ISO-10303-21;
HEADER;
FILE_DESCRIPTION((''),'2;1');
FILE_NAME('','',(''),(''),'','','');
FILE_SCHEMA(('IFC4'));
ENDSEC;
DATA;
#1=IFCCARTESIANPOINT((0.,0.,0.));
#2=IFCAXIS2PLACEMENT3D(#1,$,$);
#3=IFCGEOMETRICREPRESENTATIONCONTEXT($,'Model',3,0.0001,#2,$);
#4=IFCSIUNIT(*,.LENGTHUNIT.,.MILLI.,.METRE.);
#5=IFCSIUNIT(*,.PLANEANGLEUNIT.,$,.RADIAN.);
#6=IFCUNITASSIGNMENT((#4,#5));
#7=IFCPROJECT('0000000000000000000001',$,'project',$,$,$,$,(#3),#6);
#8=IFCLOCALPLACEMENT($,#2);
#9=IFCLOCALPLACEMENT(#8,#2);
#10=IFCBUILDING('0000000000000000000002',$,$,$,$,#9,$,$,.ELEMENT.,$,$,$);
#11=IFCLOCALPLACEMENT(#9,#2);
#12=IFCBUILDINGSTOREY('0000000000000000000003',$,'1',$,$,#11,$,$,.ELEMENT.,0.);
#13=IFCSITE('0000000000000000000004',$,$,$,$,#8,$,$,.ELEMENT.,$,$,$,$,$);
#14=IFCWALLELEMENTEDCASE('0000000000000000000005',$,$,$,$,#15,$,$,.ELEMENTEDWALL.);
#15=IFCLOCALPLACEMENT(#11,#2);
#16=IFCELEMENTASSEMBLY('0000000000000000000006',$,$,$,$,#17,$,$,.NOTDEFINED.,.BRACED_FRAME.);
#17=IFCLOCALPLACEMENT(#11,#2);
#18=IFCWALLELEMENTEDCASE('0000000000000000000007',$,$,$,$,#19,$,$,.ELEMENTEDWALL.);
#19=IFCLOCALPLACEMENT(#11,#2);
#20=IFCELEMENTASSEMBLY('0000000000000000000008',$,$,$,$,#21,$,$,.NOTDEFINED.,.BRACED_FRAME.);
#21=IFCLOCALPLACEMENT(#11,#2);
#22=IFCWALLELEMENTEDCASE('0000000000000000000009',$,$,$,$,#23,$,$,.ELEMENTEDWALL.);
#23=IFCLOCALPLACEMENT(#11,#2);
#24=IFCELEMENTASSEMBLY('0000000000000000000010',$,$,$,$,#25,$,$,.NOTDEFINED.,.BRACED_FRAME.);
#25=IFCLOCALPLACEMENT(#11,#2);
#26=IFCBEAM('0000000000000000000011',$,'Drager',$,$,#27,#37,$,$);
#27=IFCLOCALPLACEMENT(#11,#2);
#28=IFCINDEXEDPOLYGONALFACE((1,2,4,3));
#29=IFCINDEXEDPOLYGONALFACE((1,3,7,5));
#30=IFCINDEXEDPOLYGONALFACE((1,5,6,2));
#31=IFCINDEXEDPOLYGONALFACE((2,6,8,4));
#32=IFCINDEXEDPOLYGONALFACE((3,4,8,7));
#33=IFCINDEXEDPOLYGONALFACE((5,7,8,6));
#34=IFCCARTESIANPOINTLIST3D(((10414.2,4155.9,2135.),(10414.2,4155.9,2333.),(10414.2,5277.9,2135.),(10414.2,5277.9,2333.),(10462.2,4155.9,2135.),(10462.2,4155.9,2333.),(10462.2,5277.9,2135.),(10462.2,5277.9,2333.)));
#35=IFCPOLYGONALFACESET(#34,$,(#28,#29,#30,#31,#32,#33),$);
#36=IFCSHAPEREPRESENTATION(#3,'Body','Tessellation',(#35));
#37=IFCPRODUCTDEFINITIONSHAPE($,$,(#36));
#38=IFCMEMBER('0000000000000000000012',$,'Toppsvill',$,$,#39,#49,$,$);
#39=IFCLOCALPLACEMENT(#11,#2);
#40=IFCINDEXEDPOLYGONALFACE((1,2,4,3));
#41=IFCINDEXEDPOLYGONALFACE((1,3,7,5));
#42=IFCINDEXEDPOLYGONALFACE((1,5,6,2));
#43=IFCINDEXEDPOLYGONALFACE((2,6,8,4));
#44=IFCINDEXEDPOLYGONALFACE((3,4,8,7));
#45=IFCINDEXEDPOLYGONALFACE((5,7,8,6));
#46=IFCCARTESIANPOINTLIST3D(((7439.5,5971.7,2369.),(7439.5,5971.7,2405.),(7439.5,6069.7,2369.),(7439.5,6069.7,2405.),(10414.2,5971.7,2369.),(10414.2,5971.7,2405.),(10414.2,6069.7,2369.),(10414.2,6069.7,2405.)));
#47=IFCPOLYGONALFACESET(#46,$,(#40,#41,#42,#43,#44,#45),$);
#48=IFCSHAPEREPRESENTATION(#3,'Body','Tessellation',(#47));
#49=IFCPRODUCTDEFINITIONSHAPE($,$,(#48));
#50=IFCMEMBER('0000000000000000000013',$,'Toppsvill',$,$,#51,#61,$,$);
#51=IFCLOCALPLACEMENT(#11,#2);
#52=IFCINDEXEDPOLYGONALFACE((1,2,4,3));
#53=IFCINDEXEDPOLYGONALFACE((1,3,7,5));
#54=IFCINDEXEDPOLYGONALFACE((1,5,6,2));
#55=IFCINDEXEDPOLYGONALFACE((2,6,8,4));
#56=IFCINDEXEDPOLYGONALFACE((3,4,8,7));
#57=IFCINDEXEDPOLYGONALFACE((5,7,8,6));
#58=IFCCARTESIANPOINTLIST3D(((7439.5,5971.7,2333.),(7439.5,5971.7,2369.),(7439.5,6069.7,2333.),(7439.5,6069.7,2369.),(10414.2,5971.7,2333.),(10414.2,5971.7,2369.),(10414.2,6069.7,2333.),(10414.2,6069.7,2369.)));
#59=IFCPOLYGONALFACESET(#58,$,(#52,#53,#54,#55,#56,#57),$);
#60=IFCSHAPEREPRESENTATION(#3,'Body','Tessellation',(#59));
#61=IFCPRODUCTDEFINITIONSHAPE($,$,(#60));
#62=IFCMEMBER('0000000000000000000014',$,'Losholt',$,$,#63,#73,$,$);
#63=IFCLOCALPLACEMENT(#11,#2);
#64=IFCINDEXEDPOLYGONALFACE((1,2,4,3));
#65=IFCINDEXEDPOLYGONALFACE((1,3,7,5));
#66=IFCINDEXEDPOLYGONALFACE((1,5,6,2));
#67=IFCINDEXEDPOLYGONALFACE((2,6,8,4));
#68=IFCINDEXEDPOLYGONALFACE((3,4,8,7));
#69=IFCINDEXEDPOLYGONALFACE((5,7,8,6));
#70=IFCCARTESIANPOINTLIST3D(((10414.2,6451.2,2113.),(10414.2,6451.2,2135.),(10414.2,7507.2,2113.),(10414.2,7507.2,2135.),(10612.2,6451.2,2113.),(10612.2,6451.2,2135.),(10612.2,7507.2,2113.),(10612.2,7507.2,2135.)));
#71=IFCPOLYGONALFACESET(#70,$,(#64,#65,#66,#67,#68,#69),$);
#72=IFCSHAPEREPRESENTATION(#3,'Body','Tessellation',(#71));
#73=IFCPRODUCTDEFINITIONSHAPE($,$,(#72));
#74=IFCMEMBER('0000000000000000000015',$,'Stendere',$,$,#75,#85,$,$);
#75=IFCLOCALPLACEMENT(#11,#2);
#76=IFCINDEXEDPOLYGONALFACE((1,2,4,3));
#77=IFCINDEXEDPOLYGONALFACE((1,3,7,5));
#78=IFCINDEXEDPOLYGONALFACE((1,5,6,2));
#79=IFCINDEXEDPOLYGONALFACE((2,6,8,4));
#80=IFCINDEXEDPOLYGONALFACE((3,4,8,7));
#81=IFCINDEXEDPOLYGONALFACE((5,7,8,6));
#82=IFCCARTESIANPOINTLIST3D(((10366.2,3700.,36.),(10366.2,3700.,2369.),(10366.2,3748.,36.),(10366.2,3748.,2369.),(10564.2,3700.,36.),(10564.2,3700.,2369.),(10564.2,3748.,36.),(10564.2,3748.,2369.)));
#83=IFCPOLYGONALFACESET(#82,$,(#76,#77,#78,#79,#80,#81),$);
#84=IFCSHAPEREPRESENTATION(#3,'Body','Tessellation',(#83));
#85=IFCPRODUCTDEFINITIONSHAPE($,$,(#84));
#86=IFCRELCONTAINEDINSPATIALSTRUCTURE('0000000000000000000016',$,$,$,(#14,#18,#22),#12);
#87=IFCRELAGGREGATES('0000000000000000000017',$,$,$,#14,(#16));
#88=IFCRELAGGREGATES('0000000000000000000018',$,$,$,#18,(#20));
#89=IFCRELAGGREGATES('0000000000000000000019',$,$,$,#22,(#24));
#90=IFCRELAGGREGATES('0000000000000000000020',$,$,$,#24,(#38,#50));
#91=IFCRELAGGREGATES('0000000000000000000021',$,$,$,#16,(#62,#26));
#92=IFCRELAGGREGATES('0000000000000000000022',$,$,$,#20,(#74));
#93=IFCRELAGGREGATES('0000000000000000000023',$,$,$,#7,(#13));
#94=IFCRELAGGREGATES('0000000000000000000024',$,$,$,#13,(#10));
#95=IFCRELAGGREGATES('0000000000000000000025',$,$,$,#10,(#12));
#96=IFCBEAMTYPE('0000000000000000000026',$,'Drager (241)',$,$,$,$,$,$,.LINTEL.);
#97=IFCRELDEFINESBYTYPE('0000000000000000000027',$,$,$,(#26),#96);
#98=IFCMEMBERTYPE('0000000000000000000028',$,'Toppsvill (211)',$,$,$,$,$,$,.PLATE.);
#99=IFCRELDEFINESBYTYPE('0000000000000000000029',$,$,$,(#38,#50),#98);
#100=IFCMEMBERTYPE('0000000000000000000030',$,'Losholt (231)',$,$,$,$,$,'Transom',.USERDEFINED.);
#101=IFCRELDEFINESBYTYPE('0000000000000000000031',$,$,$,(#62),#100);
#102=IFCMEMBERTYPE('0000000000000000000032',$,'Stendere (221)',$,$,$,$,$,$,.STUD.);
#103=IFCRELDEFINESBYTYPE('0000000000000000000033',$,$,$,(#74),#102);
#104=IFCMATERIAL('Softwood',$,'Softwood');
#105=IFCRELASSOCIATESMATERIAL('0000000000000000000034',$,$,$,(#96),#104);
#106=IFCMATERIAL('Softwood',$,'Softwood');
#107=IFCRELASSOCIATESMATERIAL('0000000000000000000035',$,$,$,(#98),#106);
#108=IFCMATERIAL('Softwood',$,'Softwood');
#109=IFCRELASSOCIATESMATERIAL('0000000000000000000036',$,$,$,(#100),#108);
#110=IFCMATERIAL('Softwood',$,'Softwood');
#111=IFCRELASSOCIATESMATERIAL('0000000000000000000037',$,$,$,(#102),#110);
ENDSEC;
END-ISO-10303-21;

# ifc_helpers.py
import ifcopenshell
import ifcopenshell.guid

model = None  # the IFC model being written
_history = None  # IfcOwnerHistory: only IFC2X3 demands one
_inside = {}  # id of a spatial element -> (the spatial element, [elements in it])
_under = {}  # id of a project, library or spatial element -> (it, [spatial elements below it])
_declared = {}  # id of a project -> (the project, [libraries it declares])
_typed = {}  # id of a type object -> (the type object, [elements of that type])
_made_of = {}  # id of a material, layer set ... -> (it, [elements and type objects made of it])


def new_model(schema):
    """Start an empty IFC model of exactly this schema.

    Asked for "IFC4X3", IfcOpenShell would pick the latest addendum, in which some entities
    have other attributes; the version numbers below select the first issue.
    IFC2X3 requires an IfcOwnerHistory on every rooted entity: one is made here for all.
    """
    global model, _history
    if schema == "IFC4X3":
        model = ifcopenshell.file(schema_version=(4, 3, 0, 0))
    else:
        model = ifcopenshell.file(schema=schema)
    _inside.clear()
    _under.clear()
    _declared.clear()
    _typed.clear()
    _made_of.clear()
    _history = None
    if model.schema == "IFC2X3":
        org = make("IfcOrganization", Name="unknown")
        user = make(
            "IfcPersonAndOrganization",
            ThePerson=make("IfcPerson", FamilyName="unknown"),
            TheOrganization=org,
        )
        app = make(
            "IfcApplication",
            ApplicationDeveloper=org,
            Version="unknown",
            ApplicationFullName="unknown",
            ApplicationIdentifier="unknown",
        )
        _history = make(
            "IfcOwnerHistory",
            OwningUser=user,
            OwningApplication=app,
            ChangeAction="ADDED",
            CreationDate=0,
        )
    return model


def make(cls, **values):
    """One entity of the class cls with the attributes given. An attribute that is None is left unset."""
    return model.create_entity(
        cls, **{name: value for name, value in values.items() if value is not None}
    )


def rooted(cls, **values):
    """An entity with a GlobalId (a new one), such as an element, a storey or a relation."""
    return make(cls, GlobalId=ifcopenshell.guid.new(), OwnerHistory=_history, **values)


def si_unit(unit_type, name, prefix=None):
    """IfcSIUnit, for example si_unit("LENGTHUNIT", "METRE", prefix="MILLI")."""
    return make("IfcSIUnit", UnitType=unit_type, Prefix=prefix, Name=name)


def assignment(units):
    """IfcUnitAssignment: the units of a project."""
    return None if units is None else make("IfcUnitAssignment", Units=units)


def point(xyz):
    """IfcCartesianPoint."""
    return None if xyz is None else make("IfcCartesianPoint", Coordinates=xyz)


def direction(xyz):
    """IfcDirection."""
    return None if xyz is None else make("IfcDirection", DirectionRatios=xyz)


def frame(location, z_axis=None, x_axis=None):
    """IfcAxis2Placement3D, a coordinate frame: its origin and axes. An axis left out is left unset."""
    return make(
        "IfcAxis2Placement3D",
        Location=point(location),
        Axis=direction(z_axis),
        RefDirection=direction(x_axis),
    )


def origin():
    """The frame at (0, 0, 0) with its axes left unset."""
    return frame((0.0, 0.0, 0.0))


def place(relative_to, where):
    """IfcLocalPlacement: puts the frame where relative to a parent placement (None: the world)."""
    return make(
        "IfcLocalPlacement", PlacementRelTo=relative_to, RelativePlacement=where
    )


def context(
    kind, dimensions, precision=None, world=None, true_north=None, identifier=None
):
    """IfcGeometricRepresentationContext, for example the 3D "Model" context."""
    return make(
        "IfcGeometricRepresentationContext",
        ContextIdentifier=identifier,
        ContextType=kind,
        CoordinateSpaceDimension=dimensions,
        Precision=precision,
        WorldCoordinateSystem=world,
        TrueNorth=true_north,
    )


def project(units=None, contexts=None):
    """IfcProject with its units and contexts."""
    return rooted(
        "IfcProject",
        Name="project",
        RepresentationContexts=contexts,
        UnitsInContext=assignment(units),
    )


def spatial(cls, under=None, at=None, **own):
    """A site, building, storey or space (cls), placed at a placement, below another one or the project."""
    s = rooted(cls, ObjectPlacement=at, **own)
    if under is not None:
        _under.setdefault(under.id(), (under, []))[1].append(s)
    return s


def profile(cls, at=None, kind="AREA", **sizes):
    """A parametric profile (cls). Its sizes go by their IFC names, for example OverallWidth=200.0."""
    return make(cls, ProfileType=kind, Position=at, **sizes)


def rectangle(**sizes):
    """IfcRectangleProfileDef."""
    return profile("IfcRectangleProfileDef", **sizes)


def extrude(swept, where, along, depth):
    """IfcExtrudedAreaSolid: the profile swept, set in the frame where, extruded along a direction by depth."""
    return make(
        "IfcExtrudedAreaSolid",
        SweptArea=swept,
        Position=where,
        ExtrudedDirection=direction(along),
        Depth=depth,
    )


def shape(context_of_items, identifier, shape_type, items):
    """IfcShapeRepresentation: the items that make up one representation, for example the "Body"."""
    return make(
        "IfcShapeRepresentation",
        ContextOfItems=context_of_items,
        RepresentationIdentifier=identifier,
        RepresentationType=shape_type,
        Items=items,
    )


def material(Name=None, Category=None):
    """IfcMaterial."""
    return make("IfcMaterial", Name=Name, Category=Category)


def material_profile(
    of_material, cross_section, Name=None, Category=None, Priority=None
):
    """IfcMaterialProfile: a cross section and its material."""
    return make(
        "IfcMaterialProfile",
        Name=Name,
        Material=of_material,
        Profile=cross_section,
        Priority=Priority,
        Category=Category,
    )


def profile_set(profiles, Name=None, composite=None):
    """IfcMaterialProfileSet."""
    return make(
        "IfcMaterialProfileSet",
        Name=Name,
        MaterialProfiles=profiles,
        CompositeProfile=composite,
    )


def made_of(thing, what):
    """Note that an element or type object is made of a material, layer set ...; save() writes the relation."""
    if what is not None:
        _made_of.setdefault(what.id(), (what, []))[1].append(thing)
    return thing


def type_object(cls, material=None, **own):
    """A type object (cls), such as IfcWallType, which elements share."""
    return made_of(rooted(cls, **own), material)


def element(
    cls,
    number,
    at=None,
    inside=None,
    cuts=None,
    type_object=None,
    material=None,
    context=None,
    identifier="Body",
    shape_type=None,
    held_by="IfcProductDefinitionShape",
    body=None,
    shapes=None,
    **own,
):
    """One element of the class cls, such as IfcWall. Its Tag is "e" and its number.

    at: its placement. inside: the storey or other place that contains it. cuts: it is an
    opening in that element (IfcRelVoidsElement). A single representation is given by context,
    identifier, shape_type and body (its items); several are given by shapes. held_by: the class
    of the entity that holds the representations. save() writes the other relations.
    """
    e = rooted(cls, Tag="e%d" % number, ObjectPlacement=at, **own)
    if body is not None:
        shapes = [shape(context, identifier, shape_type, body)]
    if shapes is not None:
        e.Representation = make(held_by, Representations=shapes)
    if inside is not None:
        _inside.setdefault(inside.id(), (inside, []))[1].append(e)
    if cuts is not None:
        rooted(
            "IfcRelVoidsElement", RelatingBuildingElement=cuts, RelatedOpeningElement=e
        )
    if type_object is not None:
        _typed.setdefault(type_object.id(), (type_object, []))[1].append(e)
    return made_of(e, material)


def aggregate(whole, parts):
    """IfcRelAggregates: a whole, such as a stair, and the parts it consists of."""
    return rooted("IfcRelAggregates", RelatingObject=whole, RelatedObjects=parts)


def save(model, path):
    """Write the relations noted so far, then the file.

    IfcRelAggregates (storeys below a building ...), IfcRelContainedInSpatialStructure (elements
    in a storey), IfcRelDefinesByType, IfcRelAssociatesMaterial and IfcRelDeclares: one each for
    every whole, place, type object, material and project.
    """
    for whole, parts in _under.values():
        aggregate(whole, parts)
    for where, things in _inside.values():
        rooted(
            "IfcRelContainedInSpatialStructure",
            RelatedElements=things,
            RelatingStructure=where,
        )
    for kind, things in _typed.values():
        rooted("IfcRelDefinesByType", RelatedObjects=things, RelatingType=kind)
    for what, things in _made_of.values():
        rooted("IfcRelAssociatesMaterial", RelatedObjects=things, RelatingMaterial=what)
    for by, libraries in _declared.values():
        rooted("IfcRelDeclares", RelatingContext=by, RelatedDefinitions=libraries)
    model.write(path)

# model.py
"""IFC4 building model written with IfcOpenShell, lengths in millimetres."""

from ifc_helpers import new_model, si_unit, frame, origin, place, context, project, spatial, rectangle, extrude, material, material_profile, profile_set, type_object, element, aggregate, save


model = new_model("IFC4")

# Units and contexts
model_context = context("Model", 3, precision=0.0001, world=origin())
ifc_project = project(units=[si_unit("LENGTHUNIT", "METRE", prefix="MILLI"), si_unit("PLANEANGLEUNIT", "RADIAN")], contexts=[model_context])

# Site, building, storey
site_placement = place(None, origin())
site = spatial("IfcSite", under=ifc_project, at=site_placement, CompositionType="ELEMENT")
building_placement = place(site_placement, origin())
building = spatial("IfcBuilding", under=site, at=building_placement, CompositionType="ELEMENT")
storey_placement = place(building_placement, origin())
storey = spatial("IfcBuildingStorey", under=building, at=storey_placement, Name="1", CompositionType="ELEMENT", Elevation=0.0)

# Wall, element assembly
wall_1_placement = place(storey_placement, frame((10414.2, 3748.0, 0.0), z_axis=(1.0, 0.0, 0.0), x_axis=(0.0, 1.0, 0.0)))
wall_1 = element("IfcWallElementedCase", 1, at=wall_1_placement, inside=storey, PredefinedType="ELEMENTEDWALL")
assembly_1_placement = place(wall_1_placement, origin())
assembly_1 = element("IfcElementAssembly", 2, at=assembly_1_placement, AssemblyPlace="NOTDEFINED", PredefinedType="BRACED_FRAME")
aggregate(wall_1, [assembly_1])

# Wall, element assembly
wall_2_placement = place(storey_placement, frame((6576.0, 3748.0, 0.0), z_axis=(0.0, -1.0, 0.0)))
wall_2 = element("IfcWallElementedCase", 3, at=wall_2_placement, inside=storey, PredefinedType="ELEMENTEDWALL")
assembly_2_placement = place(wall_2_placement, origin())
assembly_2 = element("IfcElementAssembly", 4, at=assembly_2_placement, AssemblyPlace="NOTDEFINED", PredefinedType="BRACED_FRAME")
aggregate(wall_2, [assembly_2])

# Wall, element assembly
wall_3_placement = place(storey_placement, frame((10414.2, 5971.7, -50.0), z_axis=(0.0, 1.0, 0.0), x_axis=(-1.0, 0.0, 0.0)))
wall_3 = element("IfcWallElementedCase", 5, at=wall_3_placement, inside=storey, PredefinedType="ELEMENTEDWALL")
assembly_3_placement = place(wall_3_placement, origin())
assembly_3 = element("IfcElementAssembly", 6, at=assembly_3_placement, AssemblyPlace="NOTDEFINED", PredefinedType="BRACED_FRAME")
aggregate(wall_3, [assembly_3])

# Beam
ifc_material_1 = material(Name="Softwood", Category="Softwood")
ifc_material_profile_1 = material_profile(ifc_material_1, rectangle(XDim=198.0, YDim=48.0), Name="Drager (241)")
ifc_profile_set_1 = profile_set([ifc_material_profile_1])
beam_type = type_object("IfcBeamType", Name="Drager (241)", PredefinedType="LINTEL", material=ifc_profile_set_1)
beam_1_placement = place(assembly_1_placement, frame((407.9, 2234.0, 0.0), z_axis=(1.0, 0.0, 0.0), x_axis=(0.0, 1.0, 0.0)))
beam_1 = element("IfcBeam", 7, at=beam_1_placement, type_object=beam_type, Name="Drager", context=model_context, shape_type="SweptSolid", body=[
    extrude(rectangle(XDim=198.0, YDim=48.0), frame((0.0, 24.0, 0.0)), (0.0, 0.0, 1.0), 1122.0),
])

# Members
ifc_material_2 = material(Name="Softwood", Category="Softwood")
ifc_material_profile_2 = material_profile(ifc_material_2, rectangle(XDim=36.0, YDim=98.0), Name="Toppsvill (211)")
ifc_profile_set_2 = profile_set([ifc_material_profile_2])
member_type_1 = type_object("IfcMemberType", Name="Toppsvill (211)", PredefinedType="PLATE", material=ifc_profile_set_2)
member_1_placement = place(assembly_3_placement, frame((0.0, 2437.0, 0.0), z_axis=(1.0, 0.0, 0.0), x_axis=(0.0, 1.0, 0.0)))
member_1 = element("IfcMember", 8, at=member_1_placement, type_object=member_type_1, Name="Toppsvill", context=model_context, shape_type="SweptSolid", body=[
    extrude(rectangle(XDim=36.0, YDim=98.0), frame((0.0, 49.0, 0.0)), (0.0, 0.0, 1.0), 2974.7),
])
member_2_placement = place(assembly_3_placement, frame((0.0, 2401.0, 0.0), z_axis=(1.0, 0.0, 0.0), x_axis=(0.0, 1.0, 0.0)))
member_2 = element("IfcMember", 9, at=member_2_placement, type_object=member_type_1, Name="Toppsvill", context=model_context, shape_type="SweptSolid", body=[
    extrude(rectangle(XDim=36.0, YDim=98.0), frame((0.0, 49.0, 0.0)), (0.0, 0.0, 1.0), 2974.7),
])
aggregate(assembly_3, [member_1, member_2])
ifc_material_3 = material(Name="Softwood", Category="Softwood")
ifc_material_profile_3 = material_profile(ifc_material_3, rectangle(XDim=22.0, YDim=198.0), Name="Losholt (231)")
ifc_profile_set_3 = profile_set([ifc_material_profile_3])
member_type_2 = type_object("IfcMemberType", Name="Losholt (231)", ElementType="Transom", PredefinedType="USERDEFINED", material=ifc_profile_set_3)
member_3_placement = place(assembly_1_placement, frame((2703.2, 2124.0, 0.0), z_axis=(1.0, 0.0, 0.0), x_axis=(0.0, 1.0, 0.0)))
member_3 = element("IfcMember", 10, at=member_3_placement, type_object=member_type_2, Name="Losholt", context=model_context, shape_type="SweptSolid", body=[
    extrude(rectangle(XDim=22.0, YDim=198.0), frame((0.0, 99.0, 0.0)), (0.0, 0.0, 1.0), 1056.0),
])
aggregate(assembly_1, [member_3, beam_1])
ifc_material_4 = material(Name="Softwood", Category="Softwood")
ifc_material_profile_4 = material_profile(ifc_material_4, rectangle(XDim=198.0, YDim=48.0), Name="Stendere (221)")
ifc_profile_set_4 = profile_set([ifc_material_profile_4])
member_type_3 = type_object("IfcMemberType", Name="Stendere (221)", PredefinedType="STUD", material=ifc_profile_set_4)
member_4_placement = place(assembly_2_placement, frame((3889.2, 36.0, 0.0), z_axis=(0.0, 1.0, 0.0), x_axis=(-1.0, 0.0, 0.0)))
member_4 = element("IfcMember", 11, at=member_4_placement, type_object=member_type_3, Name="Stendere", context=model_context, shape_type="SweptSolid", body=[
    extrude(rectangle(XDim=198.0, YDim=48.0), frame((0.0, 24.0, 0.0)), (0.0, 0.0, 1.0), 2333.0),
])
aggregate(assembly_2, [member_4])

save(model, "model.ifc")
